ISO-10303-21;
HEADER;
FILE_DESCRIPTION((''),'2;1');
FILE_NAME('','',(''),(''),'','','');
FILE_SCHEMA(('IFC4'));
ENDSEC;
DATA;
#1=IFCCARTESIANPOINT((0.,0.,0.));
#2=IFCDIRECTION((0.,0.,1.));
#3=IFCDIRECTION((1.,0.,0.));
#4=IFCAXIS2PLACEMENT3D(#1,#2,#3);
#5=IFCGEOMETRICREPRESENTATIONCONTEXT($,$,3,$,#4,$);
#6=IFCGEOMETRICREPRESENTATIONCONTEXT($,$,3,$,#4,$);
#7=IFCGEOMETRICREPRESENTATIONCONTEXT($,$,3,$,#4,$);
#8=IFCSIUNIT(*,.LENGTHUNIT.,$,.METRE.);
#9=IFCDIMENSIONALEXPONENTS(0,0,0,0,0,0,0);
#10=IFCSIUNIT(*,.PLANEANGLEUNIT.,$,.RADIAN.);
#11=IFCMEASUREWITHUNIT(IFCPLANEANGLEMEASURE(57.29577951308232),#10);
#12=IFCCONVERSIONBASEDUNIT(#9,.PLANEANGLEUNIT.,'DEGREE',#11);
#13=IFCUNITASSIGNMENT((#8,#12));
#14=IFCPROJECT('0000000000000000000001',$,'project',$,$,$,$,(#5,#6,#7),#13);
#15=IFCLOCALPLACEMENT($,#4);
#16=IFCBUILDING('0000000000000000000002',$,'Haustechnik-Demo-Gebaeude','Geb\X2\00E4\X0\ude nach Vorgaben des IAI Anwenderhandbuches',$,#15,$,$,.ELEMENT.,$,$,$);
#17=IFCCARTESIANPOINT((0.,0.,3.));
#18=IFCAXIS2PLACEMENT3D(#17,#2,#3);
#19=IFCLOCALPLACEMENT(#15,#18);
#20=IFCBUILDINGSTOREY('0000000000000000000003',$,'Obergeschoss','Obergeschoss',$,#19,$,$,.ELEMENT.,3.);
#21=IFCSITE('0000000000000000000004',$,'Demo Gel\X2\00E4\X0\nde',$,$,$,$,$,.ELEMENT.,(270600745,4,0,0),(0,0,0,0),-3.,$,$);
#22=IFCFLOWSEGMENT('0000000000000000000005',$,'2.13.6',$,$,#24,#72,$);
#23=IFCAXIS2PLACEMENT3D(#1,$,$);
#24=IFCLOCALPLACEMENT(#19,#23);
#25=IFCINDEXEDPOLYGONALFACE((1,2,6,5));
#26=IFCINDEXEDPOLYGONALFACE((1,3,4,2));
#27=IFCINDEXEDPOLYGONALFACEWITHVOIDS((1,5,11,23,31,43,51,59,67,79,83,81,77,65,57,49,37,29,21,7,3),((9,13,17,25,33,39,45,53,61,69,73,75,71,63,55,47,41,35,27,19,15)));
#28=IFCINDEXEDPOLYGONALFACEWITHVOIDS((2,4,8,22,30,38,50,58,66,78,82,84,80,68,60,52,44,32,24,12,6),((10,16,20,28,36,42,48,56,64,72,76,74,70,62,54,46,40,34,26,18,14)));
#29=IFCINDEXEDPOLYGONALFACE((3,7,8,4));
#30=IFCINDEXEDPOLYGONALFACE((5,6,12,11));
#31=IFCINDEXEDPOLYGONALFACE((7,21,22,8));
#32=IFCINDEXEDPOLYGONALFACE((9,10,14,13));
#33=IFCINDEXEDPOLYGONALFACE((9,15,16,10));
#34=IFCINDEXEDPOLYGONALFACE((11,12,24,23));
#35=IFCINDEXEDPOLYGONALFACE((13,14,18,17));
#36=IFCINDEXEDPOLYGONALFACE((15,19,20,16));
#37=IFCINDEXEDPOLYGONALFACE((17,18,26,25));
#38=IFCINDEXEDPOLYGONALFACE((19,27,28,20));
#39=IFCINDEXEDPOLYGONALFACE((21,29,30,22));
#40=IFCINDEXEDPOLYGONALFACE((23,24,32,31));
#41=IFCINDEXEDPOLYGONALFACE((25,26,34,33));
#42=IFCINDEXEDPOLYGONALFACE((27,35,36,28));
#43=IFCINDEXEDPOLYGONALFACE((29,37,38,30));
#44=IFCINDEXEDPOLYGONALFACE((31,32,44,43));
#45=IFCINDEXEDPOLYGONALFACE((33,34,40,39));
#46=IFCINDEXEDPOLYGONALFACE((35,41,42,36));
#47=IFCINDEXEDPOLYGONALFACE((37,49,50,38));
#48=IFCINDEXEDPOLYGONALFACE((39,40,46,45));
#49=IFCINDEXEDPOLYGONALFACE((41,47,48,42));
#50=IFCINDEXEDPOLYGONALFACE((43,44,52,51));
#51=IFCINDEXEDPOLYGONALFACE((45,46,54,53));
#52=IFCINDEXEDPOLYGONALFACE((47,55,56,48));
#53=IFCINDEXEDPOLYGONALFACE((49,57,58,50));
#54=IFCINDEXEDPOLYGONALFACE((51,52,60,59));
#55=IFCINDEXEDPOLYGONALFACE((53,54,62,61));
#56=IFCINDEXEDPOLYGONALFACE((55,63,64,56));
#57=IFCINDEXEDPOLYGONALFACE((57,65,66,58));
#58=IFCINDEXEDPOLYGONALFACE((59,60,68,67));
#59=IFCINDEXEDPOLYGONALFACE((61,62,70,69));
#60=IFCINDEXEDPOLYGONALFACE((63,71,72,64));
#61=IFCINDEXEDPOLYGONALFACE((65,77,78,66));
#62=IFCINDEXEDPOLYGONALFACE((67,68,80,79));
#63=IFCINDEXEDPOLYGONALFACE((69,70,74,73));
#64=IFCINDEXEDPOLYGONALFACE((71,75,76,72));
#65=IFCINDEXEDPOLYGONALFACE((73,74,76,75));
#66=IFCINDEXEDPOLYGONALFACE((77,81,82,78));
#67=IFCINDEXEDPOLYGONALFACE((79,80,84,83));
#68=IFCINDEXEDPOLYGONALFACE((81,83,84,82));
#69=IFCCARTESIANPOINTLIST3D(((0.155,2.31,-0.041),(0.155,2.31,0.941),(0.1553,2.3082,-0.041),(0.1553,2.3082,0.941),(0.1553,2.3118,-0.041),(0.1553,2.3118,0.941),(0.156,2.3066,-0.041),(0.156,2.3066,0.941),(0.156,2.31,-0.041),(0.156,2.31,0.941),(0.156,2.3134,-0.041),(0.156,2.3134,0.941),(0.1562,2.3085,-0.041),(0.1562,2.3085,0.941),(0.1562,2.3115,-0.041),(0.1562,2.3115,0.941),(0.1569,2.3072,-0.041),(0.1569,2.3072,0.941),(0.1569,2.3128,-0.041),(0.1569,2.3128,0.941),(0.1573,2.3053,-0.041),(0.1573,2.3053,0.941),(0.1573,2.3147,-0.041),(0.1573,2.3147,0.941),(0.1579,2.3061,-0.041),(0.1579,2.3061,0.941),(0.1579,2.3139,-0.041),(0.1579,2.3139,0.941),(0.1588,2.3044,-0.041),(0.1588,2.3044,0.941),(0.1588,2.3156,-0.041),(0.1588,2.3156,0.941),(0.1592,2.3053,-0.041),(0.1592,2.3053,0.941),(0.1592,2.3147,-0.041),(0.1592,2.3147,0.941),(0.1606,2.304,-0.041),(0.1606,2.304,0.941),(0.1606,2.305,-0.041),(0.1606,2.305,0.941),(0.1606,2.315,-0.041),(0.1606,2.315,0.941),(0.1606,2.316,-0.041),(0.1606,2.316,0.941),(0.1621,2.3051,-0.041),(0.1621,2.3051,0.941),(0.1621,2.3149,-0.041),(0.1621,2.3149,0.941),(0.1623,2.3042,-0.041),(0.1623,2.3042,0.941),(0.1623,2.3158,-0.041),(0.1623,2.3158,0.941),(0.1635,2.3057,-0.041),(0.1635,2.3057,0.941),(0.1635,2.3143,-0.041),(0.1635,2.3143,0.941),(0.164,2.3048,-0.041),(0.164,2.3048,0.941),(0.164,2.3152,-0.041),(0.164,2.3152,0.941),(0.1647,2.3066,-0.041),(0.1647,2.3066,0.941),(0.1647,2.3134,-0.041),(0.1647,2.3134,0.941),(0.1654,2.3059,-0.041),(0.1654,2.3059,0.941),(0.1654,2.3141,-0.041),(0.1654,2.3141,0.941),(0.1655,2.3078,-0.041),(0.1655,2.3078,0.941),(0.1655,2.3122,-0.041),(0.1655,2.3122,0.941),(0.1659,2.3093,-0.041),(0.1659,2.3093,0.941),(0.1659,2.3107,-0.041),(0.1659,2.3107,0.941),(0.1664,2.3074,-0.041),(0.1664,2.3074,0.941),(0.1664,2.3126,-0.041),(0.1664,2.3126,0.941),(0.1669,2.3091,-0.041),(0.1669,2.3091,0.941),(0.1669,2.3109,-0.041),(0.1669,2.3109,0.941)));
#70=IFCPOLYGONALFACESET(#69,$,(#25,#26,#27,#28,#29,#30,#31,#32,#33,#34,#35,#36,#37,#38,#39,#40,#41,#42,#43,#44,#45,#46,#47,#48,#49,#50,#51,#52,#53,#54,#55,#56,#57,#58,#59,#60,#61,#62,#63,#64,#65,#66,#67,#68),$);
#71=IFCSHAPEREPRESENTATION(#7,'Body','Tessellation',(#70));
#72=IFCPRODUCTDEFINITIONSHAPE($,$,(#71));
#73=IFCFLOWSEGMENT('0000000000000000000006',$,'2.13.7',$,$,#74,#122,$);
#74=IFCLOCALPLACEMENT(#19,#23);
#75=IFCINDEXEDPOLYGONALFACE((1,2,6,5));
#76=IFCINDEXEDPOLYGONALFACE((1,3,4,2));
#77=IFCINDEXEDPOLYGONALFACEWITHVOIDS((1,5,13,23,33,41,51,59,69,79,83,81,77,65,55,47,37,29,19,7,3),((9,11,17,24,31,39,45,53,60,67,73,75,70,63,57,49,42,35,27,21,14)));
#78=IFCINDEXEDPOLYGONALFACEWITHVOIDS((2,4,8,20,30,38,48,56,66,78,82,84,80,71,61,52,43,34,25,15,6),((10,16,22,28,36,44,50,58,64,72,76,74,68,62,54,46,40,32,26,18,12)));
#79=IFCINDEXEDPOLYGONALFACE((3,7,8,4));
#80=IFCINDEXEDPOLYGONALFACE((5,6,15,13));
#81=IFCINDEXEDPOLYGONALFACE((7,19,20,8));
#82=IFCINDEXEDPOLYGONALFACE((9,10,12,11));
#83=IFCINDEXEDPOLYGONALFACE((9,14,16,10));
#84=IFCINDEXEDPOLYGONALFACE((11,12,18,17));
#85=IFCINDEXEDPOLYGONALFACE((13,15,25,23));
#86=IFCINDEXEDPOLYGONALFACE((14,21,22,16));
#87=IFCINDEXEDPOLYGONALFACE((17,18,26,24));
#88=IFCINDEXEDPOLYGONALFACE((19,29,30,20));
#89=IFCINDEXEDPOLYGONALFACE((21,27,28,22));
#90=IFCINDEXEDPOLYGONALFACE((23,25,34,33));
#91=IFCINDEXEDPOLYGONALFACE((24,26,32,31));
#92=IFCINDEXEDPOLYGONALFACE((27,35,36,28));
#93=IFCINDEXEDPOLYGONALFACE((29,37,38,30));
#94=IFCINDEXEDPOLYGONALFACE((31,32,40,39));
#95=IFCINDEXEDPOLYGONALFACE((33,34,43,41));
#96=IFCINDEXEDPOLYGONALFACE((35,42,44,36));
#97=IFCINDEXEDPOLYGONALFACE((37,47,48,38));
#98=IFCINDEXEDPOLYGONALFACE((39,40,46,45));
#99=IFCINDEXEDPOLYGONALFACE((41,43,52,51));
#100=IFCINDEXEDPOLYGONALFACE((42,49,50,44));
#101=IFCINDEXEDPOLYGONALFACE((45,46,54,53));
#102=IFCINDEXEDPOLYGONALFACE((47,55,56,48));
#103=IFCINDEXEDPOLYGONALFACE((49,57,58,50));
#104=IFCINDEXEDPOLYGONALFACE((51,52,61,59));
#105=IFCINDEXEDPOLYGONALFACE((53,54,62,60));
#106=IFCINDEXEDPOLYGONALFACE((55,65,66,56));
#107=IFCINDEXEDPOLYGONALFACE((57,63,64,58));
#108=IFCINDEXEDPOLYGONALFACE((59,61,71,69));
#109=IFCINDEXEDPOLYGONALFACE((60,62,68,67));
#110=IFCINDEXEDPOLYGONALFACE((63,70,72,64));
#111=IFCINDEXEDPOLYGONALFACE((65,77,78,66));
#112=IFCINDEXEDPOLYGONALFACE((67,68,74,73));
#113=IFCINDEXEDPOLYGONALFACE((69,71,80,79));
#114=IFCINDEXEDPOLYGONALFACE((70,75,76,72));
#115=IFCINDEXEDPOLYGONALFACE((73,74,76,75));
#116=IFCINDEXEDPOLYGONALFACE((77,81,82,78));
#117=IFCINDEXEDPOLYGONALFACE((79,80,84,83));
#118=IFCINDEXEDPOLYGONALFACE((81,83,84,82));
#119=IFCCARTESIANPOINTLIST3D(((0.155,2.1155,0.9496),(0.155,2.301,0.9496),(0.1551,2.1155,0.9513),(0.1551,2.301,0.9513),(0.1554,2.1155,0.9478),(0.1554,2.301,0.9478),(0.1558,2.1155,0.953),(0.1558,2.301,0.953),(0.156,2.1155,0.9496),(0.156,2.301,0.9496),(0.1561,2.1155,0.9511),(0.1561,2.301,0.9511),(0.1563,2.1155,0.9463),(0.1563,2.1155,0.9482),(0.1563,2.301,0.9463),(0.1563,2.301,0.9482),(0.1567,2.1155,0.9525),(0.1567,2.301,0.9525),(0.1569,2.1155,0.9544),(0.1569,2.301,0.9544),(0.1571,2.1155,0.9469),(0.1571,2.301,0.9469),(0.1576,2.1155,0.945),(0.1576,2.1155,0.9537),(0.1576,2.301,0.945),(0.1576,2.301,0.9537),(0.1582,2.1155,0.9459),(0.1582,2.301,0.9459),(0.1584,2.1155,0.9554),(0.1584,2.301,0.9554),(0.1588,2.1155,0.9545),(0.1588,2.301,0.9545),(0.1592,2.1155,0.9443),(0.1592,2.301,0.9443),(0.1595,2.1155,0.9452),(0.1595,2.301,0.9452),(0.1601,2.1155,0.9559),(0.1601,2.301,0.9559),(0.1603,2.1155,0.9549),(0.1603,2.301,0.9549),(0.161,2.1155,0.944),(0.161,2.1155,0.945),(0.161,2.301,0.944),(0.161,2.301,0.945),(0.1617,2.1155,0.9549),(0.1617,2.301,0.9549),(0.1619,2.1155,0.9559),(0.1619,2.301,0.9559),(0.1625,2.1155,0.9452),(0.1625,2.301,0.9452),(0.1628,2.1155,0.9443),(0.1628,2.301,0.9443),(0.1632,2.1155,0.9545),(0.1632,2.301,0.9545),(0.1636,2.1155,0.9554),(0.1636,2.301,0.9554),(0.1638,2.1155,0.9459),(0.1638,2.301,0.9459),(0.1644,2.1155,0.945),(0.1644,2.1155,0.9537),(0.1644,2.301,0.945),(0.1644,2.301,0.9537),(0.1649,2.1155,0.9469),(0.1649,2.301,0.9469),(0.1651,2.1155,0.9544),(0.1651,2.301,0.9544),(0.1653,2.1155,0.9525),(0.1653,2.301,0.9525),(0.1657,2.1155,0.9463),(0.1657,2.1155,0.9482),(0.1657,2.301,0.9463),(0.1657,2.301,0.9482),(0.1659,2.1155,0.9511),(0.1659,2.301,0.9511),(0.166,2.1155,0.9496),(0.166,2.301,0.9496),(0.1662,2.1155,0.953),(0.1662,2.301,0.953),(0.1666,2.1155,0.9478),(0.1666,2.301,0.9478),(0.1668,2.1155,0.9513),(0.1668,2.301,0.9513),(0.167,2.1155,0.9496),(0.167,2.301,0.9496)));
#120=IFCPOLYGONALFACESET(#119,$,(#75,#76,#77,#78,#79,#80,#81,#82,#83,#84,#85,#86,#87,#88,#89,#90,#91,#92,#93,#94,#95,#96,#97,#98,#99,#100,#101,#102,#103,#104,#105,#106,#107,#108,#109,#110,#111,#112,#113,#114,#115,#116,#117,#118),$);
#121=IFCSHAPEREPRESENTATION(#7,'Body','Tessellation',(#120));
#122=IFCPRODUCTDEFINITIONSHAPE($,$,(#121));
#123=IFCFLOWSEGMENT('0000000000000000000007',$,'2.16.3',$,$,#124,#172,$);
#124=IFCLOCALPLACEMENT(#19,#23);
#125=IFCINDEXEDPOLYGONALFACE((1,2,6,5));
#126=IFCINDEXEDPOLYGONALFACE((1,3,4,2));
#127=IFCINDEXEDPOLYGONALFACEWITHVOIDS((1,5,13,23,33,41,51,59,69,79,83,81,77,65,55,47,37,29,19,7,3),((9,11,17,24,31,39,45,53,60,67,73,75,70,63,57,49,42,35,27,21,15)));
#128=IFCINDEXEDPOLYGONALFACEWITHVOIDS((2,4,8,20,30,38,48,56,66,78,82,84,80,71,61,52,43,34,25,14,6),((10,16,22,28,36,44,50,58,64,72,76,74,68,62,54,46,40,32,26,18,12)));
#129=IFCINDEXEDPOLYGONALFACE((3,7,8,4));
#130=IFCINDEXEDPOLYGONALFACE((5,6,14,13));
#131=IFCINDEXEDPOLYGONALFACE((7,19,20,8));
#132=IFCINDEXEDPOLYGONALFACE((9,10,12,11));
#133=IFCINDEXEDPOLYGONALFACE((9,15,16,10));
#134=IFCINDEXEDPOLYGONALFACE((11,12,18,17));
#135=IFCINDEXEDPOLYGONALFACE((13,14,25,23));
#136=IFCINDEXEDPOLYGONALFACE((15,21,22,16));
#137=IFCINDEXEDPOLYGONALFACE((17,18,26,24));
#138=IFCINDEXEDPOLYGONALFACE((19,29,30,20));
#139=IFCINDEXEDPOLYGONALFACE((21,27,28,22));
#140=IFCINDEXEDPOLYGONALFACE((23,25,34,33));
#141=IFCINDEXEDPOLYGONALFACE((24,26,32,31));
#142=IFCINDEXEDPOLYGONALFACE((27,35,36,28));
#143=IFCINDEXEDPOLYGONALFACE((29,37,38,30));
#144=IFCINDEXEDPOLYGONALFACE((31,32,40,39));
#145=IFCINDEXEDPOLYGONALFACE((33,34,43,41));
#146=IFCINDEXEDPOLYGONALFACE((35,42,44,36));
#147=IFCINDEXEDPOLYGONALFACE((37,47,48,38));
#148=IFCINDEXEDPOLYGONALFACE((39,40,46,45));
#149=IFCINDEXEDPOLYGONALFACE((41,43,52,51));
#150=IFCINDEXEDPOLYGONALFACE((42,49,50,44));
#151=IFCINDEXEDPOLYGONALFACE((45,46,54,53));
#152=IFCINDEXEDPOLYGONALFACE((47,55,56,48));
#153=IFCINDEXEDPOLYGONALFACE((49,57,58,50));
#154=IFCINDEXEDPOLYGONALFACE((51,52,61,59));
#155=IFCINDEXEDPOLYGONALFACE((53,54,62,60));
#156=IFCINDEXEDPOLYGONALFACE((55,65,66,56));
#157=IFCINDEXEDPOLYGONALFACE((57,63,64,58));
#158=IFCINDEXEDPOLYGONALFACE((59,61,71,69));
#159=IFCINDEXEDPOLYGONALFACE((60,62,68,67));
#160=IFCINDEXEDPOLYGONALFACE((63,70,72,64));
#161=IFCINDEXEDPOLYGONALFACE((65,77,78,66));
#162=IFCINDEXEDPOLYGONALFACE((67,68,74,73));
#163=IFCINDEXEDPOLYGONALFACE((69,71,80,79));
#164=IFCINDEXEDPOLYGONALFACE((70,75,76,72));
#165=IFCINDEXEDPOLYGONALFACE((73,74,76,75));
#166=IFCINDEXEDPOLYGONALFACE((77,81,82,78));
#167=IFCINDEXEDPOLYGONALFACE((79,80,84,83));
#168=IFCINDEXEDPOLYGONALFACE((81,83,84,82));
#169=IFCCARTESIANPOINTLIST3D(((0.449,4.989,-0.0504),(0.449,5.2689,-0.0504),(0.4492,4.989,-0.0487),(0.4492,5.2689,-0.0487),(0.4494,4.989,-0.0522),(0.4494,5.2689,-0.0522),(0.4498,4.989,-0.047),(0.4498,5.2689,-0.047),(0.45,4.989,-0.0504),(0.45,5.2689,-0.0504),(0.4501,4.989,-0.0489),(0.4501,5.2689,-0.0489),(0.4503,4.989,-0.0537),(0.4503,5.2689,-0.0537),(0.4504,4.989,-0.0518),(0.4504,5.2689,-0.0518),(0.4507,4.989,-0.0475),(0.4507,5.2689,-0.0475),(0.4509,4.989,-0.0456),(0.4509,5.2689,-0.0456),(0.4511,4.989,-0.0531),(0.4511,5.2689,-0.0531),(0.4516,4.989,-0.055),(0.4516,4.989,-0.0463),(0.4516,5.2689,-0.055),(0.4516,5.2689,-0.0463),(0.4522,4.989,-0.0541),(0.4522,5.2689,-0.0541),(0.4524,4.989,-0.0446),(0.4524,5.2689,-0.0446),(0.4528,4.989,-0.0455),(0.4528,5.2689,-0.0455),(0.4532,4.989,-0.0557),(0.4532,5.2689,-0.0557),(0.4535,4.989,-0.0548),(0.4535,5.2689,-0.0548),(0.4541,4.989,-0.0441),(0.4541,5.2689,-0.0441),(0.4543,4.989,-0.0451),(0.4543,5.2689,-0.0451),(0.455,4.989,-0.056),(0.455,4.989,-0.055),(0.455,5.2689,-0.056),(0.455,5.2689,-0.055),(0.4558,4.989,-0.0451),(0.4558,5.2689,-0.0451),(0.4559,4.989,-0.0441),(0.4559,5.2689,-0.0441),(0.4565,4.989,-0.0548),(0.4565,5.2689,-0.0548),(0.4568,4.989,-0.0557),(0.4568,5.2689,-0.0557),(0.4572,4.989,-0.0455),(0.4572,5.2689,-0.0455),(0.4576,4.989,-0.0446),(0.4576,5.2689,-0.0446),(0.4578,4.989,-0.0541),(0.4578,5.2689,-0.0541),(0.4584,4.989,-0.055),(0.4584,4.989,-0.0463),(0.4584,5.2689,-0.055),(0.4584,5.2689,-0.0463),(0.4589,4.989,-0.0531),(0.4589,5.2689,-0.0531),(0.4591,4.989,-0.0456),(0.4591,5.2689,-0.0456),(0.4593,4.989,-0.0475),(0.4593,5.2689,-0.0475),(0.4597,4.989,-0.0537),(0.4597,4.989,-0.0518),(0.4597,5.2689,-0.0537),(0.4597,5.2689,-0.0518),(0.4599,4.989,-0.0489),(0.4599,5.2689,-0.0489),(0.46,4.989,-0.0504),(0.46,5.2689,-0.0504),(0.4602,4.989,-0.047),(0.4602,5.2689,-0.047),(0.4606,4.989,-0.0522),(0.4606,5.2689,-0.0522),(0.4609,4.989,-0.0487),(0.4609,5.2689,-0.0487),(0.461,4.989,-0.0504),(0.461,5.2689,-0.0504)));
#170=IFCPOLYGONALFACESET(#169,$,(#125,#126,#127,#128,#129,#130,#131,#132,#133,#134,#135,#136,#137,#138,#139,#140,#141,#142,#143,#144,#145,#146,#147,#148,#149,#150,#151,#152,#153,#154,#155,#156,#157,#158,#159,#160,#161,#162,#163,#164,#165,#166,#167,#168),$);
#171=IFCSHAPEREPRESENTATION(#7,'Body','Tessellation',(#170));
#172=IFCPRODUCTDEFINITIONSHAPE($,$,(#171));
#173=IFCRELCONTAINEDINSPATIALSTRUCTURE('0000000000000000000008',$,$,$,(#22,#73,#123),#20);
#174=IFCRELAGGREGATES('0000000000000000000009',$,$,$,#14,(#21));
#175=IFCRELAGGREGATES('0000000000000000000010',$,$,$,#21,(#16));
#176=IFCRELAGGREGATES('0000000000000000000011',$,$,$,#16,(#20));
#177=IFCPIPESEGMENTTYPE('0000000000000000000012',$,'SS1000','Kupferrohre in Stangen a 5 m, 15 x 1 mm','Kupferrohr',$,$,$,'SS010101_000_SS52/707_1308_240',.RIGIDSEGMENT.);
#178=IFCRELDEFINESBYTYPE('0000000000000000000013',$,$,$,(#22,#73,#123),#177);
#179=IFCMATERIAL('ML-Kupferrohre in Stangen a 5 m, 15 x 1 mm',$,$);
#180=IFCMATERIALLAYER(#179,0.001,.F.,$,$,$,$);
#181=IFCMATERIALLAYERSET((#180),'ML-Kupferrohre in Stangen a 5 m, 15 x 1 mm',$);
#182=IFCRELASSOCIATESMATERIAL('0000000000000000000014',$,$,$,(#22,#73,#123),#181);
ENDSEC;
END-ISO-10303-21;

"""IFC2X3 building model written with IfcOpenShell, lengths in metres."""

from ifc_helpers import new_model, entity, si_unit, converted_unit, frame, origin_with_axes, origin_2d_with_axis, place, context, project, spatial, hollow_circle, extrude, material, layer, layer_set, layer_usage, type_object, element, save


model = new_model("IFC2X3")

# Units and contexts
context_of_model_1 = context(None, 3, world=origin_with_axes())
context_of_model_2 = context(None, 3, world=origin_with_axes())
context_of_model_3 = context(None, 3, world=origin_with_axes())
ifc_project = project(units=[si_unit("LENGTHUNIT", "METRE"), converted_unit("PLANEANGLEUNIT", "DEGREE", entity("IfcPlaneAngleMeasure", 57.29577951308232), si_unit("PLANEANGLEUNIT", "RADIAN"), dimensions=[0, 0, 0, 0, 0, 0, 0])], contexts=[context_of_model_1, context_of_model_2, context_of_model_3])

# Site, building, storey
site = spatial("IfcSite", under=ifc_project, Name="Demo Gelände", CompositionType="ELEMENT", RefLatitude=(270600745, 4, 0, 0), RefLongitude=(0, 0, 0, 0), RefElevation=-3.0)
building_placement = place(None, origin_with_axes())
building = spatial("IfcBuilding", under=site, at=building_placement, Name="Haustechnik-Demo-Gebaeude", Description="Gebäude nach Vorgaben des IAI Anwenderhandbuches", CompositionType="ELEMENT")
storey_placement = place(building_placement, frame((0.0, 0.0, 3.0), z_axis=(0.0, 0.0, 1.0), x_axis=(1.0, 0.0, 0.0)))
storey = spatial("IfcBuildingStorey", under=building, at=storey_placement, Name="Obergeschoss", Description="Obergeschoss", CompositionType="ELEMENT", Elevation=3.0)

# Flow segments
ifc_material = material(Name="ML-Kupferrohre in Stangen a 5 m, 15 x 1 mm")
ifc_layer = layer(ifc_material, 0.001, ventilated=False)
ifc_layer_set = layer_set([ifc_layer], Name="ML-Kupferrohre in Stangen a 5 m, 15 x 1 mm")
ifc_layer_usage = layer_usage(ifc_layer_set, "AXIS2", "POSITIVE", 0.0)
pipe_segment_type_1 = type_object("IfcPipeSegmentType", Name="SS1000", Description="Kupferrohre in Stangen a 5 m, 15 x 1 mm", ApplicableOccurrence="Kupferrohr", ElementType="SS010101_000_SS52/707_1308_240", PredefinedType="RIGIDSEGMENT")
flow_segment_1_placement = place(storey_placement, frame((0.161, 2.31, -0.041), z_axis=(0.0, 0.0, 1.0), x_axis=(-1.0, 0.0, 0.0)))
element("IfcFlowSegment", 1, at=flow_segment_1_placement, inside=storey, type_object=pipe_segment_type_1, material=ifc_layer_usage, Name="2.13.6", context=context_of_model_3, shape_type="SweptSolid", body=[
    extrude(hollow_circle(Radius=0.006, WallThickness=0.001, at=origin_2d_with_axis()), origin_with_axes(), (0.0, 0.0, 1.0), 0.982),
])
flow_segment_2_placement = place(storey_placement, frame((0.161, 2.301, 0.95), z_axis=(0.0, -1.0, 0.0), x_axis=(0.0, 0.0, -1.0)))
element("IfcFlowSegment", 2, at=flow_segment_2_placement, inside=storey, type_object=pipe_segment_type_1, material=ifc_layer_usage, Name="2.13.7", context=context_of_model_3, shape_type="SweptSolid", body=[
    extrude(hollow_circle(Radius=0.006, WallThickness=0.001, at=origin_2d_with_axis()), origin_with_axes(), (0.0, 0.0, 1.0), 0.1855),
])
flow_segment_3_placement = place(storey_placement, frame((0.455, 4.989, -0.05), z_axis=(0.0, 1.0, 0.0), x_axis=(0.0, 0.0, -1.0)))
element("IfcFlowSegment", 3, at=flow_segment_3_placement, inside=storey, type_object=pipe_segment_type_1, material=ifc_layer_usage, Name="2.16.3", context=context_of_model_3, shape_type="SweptSolid", body=[
    extrude(hollow_circle(Radius=0.006, WallThickness=0.001, at=origin_2d_with_axis()), origin_with_axes(), (0.0, 0.0, 1.0), 0.2799),
])

save(model, "model.ifc")
